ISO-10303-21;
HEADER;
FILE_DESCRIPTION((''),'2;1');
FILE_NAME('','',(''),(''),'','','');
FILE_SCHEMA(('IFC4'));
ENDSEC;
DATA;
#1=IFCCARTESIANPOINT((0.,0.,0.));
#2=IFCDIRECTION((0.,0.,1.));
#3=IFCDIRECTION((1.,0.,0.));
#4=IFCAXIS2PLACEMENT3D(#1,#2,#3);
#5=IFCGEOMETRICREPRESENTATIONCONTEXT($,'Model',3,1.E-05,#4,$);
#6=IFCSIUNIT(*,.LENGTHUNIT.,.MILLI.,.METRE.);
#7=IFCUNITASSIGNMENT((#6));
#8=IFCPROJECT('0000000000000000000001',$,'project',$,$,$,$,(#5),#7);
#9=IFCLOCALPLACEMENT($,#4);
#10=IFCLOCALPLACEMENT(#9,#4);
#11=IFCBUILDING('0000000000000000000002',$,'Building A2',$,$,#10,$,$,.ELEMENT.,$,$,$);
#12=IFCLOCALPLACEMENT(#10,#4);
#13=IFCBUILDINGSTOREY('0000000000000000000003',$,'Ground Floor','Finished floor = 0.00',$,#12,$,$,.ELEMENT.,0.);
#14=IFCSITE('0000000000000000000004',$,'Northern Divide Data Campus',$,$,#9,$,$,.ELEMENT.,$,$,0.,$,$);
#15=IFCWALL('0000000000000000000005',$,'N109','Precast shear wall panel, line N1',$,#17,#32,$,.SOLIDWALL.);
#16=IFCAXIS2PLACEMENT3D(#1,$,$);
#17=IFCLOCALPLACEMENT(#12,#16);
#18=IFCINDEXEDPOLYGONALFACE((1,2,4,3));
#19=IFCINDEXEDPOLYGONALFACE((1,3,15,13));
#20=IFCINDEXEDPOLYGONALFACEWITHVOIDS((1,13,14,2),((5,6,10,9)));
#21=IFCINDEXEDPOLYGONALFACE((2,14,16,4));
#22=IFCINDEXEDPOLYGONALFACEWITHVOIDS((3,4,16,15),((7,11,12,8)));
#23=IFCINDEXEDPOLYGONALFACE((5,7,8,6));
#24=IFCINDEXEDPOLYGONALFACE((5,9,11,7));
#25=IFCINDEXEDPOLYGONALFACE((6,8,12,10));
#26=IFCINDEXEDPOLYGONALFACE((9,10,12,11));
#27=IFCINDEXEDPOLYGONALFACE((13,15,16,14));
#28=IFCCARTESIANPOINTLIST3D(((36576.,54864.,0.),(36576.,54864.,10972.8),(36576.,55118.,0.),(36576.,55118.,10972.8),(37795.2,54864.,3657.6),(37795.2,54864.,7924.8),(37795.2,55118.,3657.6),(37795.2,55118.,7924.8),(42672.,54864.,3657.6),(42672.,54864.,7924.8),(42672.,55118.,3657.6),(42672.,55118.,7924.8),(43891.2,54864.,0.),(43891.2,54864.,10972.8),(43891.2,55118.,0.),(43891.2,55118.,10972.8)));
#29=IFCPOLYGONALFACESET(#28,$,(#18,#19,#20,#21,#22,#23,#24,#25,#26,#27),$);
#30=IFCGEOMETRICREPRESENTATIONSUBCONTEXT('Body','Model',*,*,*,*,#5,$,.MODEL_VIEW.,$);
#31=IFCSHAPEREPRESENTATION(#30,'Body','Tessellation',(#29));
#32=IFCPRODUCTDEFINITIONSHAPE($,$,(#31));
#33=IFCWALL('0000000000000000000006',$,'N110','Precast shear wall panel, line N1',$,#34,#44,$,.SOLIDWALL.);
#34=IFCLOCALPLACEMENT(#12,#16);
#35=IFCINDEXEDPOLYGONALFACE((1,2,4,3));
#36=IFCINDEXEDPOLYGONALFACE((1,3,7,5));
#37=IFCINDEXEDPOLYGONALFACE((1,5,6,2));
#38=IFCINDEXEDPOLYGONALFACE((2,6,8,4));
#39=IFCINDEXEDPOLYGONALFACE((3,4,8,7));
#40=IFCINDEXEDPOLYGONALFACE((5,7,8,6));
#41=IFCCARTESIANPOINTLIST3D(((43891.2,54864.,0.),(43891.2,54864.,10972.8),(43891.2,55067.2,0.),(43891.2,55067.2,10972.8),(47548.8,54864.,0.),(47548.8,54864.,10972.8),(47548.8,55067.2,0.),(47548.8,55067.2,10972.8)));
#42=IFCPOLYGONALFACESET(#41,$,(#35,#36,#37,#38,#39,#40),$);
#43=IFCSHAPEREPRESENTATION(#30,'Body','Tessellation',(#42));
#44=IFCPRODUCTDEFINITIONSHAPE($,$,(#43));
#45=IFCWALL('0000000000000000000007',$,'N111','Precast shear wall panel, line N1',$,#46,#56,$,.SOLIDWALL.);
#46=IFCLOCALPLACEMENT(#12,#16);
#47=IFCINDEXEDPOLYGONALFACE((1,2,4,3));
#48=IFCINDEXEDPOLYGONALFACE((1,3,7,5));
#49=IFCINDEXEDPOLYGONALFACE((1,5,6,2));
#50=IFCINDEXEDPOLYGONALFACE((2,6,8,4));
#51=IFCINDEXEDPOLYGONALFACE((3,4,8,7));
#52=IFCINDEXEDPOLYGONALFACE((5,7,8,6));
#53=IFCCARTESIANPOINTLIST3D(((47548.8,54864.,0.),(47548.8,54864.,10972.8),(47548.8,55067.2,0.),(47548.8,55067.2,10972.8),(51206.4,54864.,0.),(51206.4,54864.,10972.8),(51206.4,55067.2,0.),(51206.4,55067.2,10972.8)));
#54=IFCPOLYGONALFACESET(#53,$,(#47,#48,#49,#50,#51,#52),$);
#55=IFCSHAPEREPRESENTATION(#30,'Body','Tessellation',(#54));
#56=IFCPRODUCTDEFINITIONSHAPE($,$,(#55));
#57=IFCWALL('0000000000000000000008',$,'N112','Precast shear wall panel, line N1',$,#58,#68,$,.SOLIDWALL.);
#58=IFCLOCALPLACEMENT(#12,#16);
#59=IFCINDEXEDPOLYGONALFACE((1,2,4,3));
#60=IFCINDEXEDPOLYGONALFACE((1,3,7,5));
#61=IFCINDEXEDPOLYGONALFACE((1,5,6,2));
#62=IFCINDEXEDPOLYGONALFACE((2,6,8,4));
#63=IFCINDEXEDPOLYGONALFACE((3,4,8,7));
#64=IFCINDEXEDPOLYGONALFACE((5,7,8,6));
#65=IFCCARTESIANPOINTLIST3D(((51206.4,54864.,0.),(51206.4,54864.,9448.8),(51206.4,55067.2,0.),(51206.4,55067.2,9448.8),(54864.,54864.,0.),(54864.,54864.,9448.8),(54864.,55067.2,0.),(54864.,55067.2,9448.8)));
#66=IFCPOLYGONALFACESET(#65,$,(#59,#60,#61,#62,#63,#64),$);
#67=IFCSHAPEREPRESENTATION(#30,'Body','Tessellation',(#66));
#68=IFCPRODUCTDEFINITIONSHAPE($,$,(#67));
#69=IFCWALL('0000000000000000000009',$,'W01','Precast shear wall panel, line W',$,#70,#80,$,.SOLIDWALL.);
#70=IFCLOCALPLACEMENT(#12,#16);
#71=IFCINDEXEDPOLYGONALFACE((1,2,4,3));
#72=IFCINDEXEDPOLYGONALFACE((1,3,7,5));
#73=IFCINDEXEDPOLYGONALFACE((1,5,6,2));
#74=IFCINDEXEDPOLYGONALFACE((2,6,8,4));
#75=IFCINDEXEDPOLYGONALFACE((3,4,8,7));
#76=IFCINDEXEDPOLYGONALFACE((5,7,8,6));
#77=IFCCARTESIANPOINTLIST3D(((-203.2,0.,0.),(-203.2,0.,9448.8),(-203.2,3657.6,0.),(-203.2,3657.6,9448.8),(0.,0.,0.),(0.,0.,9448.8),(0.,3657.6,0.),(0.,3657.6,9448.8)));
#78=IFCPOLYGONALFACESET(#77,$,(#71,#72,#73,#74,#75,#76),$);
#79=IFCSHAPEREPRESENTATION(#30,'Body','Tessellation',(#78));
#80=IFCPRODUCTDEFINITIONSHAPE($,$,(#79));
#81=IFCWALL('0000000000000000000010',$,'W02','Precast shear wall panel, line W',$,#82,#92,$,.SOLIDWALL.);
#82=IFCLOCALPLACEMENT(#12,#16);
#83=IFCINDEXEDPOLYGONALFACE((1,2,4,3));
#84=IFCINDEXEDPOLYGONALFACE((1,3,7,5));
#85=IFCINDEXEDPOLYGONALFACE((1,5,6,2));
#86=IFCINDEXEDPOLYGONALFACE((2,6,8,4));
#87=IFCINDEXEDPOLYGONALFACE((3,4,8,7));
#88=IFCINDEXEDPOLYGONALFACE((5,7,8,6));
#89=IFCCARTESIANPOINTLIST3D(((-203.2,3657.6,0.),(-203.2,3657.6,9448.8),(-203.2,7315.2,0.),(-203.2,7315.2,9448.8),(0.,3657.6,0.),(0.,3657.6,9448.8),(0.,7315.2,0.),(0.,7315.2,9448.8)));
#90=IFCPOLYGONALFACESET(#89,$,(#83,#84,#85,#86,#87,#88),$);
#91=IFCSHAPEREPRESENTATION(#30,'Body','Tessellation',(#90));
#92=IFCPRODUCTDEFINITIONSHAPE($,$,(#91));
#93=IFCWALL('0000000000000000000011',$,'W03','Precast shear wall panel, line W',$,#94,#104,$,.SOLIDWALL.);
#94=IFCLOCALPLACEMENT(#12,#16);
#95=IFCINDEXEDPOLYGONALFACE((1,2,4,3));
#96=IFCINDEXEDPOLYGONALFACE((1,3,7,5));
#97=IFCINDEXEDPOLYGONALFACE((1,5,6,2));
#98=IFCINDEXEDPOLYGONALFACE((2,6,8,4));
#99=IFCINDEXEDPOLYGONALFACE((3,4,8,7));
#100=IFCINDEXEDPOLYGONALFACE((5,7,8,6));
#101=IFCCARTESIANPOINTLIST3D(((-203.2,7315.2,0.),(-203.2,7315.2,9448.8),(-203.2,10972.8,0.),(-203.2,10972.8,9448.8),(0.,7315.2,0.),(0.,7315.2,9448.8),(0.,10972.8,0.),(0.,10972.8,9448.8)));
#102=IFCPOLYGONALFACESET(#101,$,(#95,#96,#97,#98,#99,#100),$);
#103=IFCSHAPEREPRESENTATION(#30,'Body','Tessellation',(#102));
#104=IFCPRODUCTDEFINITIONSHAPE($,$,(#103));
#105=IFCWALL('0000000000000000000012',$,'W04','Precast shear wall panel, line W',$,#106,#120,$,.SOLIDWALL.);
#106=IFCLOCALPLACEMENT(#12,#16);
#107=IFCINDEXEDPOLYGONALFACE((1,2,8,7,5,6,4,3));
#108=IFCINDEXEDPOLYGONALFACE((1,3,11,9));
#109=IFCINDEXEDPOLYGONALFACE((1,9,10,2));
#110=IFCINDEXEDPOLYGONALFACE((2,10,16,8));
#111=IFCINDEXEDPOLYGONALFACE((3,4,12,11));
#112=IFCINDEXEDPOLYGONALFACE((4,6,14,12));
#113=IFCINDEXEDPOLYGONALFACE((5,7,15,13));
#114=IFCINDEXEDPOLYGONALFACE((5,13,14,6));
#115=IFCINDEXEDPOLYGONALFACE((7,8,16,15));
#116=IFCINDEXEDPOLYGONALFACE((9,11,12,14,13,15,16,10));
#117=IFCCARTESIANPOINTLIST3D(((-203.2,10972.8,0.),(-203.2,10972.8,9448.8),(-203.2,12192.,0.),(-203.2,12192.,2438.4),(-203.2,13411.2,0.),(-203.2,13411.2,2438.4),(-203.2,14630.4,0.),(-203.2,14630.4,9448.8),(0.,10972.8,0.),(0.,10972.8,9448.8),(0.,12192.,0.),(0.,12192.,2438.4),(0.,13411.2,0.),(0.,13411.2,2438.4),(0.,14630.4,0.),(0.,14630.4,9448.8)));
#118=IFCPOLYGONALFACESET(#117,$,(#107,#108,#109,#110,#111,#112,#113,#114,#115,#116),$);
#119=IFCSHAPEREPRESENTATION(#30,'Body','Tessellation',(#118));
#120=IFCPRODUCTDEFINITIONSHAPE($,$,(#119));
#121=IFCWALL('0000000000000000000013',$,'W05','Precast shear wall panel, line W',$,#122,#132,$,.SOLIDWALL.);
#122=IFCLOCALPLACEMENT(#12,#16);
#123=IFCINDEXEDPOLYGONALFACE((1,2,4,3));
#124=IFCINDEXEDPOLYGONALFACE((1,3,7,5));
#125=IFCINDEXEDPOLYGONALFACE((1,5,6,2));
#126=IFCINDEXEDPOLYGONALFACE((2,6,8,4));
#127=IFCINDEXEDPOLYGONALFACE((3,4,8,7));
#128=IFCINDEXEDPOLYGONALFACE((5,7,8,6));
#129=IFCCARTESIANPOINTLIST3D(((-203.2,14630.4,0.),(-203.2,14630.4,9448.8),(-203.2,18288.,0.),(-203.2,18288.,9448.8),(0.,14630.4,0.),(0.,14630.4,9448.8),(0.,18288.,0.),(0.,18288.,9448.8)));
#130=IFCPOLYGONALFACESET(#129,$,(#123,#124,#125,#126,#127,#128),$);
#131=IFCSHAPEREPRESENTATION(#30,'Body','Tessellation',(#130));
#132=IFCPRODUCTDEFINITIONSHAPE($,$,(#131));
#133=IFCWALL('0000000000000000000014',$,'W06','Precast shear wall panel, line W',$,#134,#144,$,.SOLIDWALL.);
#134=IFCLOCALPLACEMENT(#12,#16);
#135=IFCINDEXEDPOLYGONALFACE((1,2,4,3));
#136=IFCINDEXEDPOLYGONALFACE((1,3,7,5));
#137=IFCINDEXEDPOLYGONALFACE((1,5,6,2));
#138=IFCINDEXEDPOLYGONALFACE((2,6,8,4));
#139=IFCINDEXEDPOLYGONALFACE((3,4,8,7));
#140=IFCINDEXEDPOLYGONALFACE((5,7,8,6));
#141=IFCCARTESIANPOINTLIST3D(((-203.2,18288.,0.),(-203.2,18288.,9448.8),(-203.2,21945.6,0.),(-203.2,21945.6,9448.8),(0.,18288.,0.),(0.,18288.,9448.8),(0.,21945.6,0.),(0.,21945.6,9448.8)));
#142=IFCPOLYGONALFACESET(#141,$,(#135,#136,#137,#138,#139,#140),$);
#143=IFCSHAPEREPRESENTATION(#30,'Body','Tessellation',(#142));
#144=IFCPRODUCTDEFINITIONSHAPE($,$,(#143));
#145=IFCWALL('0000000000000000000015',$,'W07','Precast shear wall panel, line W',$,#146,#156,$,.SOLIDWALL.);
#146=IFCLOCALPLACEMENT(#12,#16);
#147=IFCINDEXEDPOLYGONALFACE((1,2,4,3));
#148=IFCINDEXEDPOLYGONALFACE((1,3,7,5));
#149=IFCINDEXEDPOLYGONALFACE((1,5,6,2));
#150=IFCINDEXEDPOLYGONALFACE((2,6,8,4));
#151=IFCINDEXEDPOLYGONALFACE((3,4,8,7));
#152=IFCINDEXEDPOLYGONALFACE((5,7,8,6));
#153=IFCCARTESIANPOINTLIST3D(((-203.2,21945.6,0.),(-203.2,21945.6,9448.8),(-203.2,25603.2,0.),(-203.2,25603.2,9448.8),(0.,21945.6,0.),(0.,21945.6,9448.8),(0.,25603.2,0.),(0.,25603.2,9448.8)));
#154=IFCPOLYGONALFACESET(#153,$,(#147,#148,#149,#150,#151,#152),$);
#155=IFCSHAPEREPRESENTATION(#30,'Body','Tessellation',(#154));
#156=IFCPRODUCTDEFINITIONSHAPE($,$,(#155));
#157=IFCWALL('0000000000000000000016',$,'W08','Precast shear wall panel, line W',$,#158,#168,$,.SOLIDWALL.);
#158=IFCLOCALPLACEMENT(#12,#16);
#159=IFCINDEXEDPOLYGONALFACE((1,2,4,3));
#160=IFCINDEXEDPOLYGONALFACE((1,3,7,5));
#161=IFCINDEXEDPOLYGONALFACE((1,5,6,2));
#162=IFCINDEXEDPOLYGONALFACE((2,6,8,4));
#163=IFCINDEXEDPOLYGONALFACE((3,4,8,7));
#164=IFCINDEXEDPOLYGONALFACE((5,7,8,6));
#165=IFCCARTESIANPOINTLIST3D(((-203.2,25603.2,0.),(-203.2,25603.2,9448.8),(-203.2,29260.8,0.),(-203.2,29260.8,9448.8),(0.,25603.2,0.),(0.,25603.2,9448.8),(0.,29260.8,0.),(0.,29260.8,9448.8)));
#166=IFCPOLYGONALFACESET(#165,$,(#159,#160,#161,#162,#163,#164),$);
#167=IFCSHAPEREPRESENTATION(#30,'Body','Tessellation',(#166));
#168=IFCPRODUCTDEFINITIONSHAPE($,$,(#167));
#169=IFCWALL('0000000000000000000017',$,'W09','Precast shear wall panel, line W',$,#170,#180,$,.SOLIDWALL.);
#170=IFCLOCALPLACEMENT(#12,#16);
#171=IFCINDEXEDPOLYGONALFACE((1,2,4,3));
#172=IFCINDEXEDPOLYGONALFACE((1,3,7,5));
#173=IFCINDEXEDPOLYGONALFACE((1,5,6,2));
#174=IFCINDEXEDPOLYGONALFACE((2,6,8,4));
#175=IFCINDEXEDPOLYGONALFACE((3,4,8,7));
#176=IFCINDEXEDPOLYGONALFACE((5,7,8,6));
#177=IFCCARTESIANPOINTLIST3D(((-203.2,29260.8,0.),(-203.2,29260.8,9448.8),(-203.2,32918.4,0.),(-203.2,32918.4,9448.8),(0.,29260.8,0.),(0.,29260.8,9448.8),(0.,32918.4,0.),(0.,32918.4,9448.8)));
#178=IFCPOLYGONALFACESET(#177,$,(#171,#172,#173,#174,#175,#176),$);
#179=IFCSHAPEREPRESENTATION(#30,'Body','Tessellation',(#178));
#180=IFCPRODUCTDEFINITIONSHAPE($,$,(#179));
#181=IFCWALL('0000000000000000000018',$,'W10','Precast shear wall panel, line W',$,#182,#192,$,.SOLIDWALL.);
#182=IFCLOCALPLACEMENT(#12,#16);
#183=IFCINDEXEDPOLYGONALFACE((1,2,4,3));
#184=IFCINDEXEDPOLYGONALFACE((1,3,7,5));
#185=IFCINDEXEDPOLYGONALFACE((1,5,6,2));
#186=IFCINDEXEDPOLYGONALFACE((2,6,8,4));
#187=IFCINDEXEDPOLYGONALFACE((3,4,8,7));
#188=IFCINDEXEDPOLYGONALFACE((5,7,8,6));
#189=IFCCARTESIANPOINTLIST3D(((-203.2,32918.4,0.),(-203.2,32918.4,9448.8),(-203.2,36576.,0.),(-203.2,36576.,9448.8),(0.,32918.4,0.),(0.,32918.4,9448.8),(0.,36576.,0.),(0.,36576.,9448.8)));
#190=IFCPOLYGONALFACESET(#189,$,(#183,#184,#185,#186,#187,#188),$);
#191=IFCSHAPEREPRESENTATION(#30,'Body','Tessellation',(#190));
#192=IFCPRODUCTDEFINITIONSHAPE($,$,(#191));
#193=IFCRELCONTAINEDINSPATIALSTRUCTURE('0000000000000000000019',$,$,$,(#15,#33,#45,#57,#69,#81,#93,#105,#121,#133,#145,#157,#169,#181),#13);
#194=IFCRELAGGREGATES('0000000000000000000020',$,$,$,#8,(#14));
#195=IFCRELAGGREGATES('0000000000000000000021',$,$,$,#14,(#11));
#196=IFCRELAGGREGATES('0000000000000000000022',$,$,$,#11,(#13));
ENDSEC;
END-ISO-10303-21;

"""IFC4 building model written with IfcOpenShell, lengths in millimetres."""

from ifc_helpers import new_model, si_unit, frame, origin, origin_with_axes, place, context, subcontext, project, spatial, polyline, outline, extrude, element, save


model = new_model("IFC4")

# Units and contexts
model_context = context("Model", 3, precision=1e-05, world=origin_with_axes())
body_context = subcontext(model_context, "Body", "Model", "MODEL_VIEW")
ifc_project = project(units=[si_unit("LENGTHUNIT", "METRE", prefix="MILLI")], contexts=[model_context])

# Site, building, storey
site_placement = place(None, origin_with_axes())
site = spatial("IfcSite", under=ifc_project, at=site_placement, Name="Northern Divide Data Campus", CompositionType="ELEMENT", RefElevation=0.0)
building_placement = place(site_placement, origin_with_axes())
building = spatial("IfcBuilding", under=site, at=building_placement, Name="Building A2", CompositionType="ELEMENT")
storey_placement = place(building_placement, origin_with_axes())
storey = spatial("IfcBuildingStorey", under=building, at=storey_placement, Name="Ground Floor", Description="Finished floor = 0.00", CompositionType="ELEMENT", Elevation=0.0)

# Wall, opening
wall_1_placement = place(storey_placement, origin_with_axes())
wall_1 = element("IfcWall", 1, at=wall_1_placement, inside=storey, Name="N109", Description="Precast shear wall panel, line N1", PredefinedType="SOLIDWALL", context=body_context, shape_type="SweptSolid", body=[
    extrude(outline(polyline([(36576.0, 54864.0), (43891.2, 54864.0), (43891.2, 55118.0), (36576.0, 55118.0), (36576.0, 54864.0)])), origin(), (0.0, 0.0, 1.0), 10972.8),
])
opening_1_placement = place(storey_placement, origin_with_axes())
element("IfcOpeningElement", 2, at=opening_1_placement, cuts=wall_1, PredefinedType="OPENING", context=body_context, shape_type="SweptSolid", body=[
    extrude(outline(polyline([(37795.2, 54864.0), (42672.0, 54864.0), (42672.0, 55118.0), (37795.2, 55118.0), (37795.2, 54864.0)])), frame((0.0, 0.0, 3657.6), z_axis=(0.0, 0.0, 1.0), x_axis=(1.0, 0.0, 0.0)), (0.0, 0.0, 1.0), 4267.2),
])

# Walls
wall_2_placement = place(storey_placement, origin_with_axes())
element("IfcWall", 3, at=wall_2_placement, inside=storey, Name="N110", Description="Precast shear wall panel, line N1", PredefinedType="SOLIDWALL", context=body_context, shape_type="SweptSolid", body=[
    extrude(outline(polyline([(43891.2, 54864.0), (47548.8, 54864.0), (47548.8, 55067.2), (43891.2, 55067.2), (43891.2, 54864.0)])), origin(), (0.0, 0.0, 1.0), 10972.8),
])
wall_3_placement = place(storey_placement, origin_with_axes())
element("IfcWall", 4, at=wall_3_placement, inside=storey, Name="N111", Description="Precast shear wall panel, line N1", PredefinedType="SOLIDWALL", context=body_context, shape_type="SweptSolid", body=[
    extrude(outline(polyline([(47548.8, 54864.0), (51206.4, 54864.0), (51206.4, 55067.2), (47548.8, 55067.2), (47548.8, 54864.0)])), origin(), (0.0, 0.0, 1.0), 10972.8),
])
wall_4_placement = place(storey_placement, origin_with_axes())
element("IfcWall", 5, at=wall_4_placement, inside=storey, Name="N112", Description="Precast shear wall panel, line N1", PredefinedType="SOLIDWALL", context=body_context, shape_type="SweptSolid", body=[
    extrude(outline(polyline([(51206.4, 54864.0), (54864.0, 54864.0), (54864.0, 55067.2), (51206.4, 55067.2), (51206.4, 54864.0)])), origin(), (0.0, 0.0, 1.0), 9448.8),
])
wall_5_placement = place(storey_placement, origin_with_axes())
element("IfcWall", 6, at=wall_5_placement, inside=storey, Name="W01", Description="Precast shear wall panel, line W", PredefinedType="SOLIDWALL", context=body_context, shape_type="SweptSolid", body=[
    extrude(outline(polyline([(-203.2, 0.0), (0.0, 0.0), (0.0, 3657.6), (-203.2, 3657.6), (-203.2, 0.0)])), origin(), (0.0, 0.0, 1.0), 9448.8),
])
wall_6_placement = place(storey_placement, origin_with_axes())
element("IfcWall", 7, at=wall_6_placement, inside=storey, Name="W02", Description="Precast shear wall panel, line W", PredefinedType="SOLIDWALL", context=body_context, shape_type="SweptSolid", body=[
    extrude(outline(polyline([(-203.2, 3657.6), (0.0, 3657.6), (0.0, 7315.2), (-203.2, 7315.2), (-203.2, 3657.6)])), origin(), (0.0, 0.0, 1.0), 9448.8),
])
wall_7_placement = place(storey_placement, origin_with_axes())
element("IfcWall", 8, at=wall_7_placement, inside=storey, Name="W03", Description="Precast shear wall panel, line W", PredefinedType="SOLIDWALL", context=body_context, shape_type="SweptSolid", body=[
    extrude(outline(polyline([(-203.2, 7315.2), (0.0, 7315.2), (0.0, 10972.8), (-203.2, 10972.8), (-203.2, 7315.2)])), origin(), (0.0, 0.0, 1.0), 9448.8),
])

# Wall, opening
wall_8_placement = place(storey_placement, origin_with_axes())
wall_8 = element("IfcWall", 9, at=wall_8_placement, inside=storey, Name="W04", Description="Precast shear wall panel, line W", PredefinedType="SOLIDWALL", context=body_context, shape_type="SweptSolid", body=[
    extrude(outline(polyline([(-203.2, 10972.8), (0.0, 10972.8), (0.0, 14630.4), (-203.2, 14630.4), (-203.2, 10972.8)])), origin(), (0.0, 0.0, 1.0), 9448.8),
])
opening_2_placement = place(storey_placement, origin_with_axes())
element("IfcOpeningElement", 10, at=opening_2_placement, cuts=wall_8, PredefinedType="OPENING", context=body_context, shape_type="SweptSolid", body=[
    extrude(outline(polyline([(-203.2, 12192.0), (0.0, 12192.0), (0.0, 13411.2), (-203.2, 13411.2), (-203.2, 12192.0)])), origin_with_axes(), (0.0, 0.0, 1.0), 2438.4),
])

# Walls
wall_9_placement = place(storey_placement, origin_with_axes())
element("IfcWall", 11, at=wall_9_placement, inside=storey, Name="W05", Description="Precast shear wall panel, line W", PredefinedType="SOLIDWALL", context=body_context, shape_type="SweptSolid", body=[
    extrude(outline(polyline([(-203.2, 14630.4), (0.0, 14630.4), (0.0, 18288.0), (-203.2, 18288.0), (-203.2, 14630.4)])), origin(), (0.0, 0.0, 1.0), 9448.8),
])
wall_10_placement = place(storey_placement, origin_with_axes())
element("IfcWall", 12, at=wall_10_placement, inside=storey, Name="W06", Description="Precast shear wall panel, line W", PredefinedType="SOLIDWALL", context=body_context, shape_type="SweptSolid", body=[
    extrude(outline(polyline([(-203.2, 18288.0), (0.0, 18288.0), (0.0, 21945.6), (-203.2, 21945.6), (-203.2, 18288.0)])), origin(), (0.0, 0.0, 1.0), 9448.8),
])
wall_11_placement = place(storey_placement, origin_with_axes())
element("IfcWall", 13, at=wall_11_placement, inside=storey, Name="W07", Description="Precast shear wall panel, line W", PredefinedType="SOLIDWALL", context=body_context, shape_type="SweptSolid", body=[
    extrude(outline(polyline([(-203.2, 21945.6), (0.0, 21945.6), (0.0, 25603.2), (-203.2, 25603.2), (-203.2, 21945.6)])), origin(), (0.0, 0.0, 1.0), 9448.8),
])
wall_12_placement = place(storey_placement, origin_with_axes())
element("IfcWall", 14, at=wall_12_placement, inside=storey, Name="W08", Description="Precast shear wall panel, line W", PredefinedType="SOLIDWALL", context=body_context, shape_type="SweptSolid", body=[
    extrude(outline(polyline([(-203.2, 25603.2), (0.0, 25603.2), (0.0, 29260.8), (-203.2, 29260.8), (-203.2, 25603.2)])), origin(), (0.0, 0.0, 1.0), 9448.8),
])
wall_13_placement = place(storey_placement, origin_with_axes())
element("IfcWall", 15, at=wall_13_placement, inside=storey, Name="W09", Description="Precast shear wall panel, line W", PredefinedType="SOLIDWALL", context=body_context, shape_type="SweptSolid", body=[
    extrude(outline(polyline([(-203.2, 29260.8), (0.0, 29260.8), (0.0, 32918.4), (-203.2, 32918.4), (-203.2, 29260.8)])), origin(), (0.0, 0.0, 1.0), 9448.8),
])
wall_14_placement = place(storey_placement, origin_with_axes())
element("IfcWall", 16, at=wall_14_placement, inside=storey, Name="W10", Description="Precast shear wall panel, line W", PredefinedType="SOLIDWALL", context=body_context, shape_type="SweptSolid", body=[
    extrude(outline(polyline([(-203.2, 32918.4), (0.0, 32918.4), (0.0, 36576.0), (-203.2, 36576.0), (-203.2, 32918.4)])), origin(), (0.0, 0.0, 1.0), 9448.8),
])

save(model, "model.ifc")
